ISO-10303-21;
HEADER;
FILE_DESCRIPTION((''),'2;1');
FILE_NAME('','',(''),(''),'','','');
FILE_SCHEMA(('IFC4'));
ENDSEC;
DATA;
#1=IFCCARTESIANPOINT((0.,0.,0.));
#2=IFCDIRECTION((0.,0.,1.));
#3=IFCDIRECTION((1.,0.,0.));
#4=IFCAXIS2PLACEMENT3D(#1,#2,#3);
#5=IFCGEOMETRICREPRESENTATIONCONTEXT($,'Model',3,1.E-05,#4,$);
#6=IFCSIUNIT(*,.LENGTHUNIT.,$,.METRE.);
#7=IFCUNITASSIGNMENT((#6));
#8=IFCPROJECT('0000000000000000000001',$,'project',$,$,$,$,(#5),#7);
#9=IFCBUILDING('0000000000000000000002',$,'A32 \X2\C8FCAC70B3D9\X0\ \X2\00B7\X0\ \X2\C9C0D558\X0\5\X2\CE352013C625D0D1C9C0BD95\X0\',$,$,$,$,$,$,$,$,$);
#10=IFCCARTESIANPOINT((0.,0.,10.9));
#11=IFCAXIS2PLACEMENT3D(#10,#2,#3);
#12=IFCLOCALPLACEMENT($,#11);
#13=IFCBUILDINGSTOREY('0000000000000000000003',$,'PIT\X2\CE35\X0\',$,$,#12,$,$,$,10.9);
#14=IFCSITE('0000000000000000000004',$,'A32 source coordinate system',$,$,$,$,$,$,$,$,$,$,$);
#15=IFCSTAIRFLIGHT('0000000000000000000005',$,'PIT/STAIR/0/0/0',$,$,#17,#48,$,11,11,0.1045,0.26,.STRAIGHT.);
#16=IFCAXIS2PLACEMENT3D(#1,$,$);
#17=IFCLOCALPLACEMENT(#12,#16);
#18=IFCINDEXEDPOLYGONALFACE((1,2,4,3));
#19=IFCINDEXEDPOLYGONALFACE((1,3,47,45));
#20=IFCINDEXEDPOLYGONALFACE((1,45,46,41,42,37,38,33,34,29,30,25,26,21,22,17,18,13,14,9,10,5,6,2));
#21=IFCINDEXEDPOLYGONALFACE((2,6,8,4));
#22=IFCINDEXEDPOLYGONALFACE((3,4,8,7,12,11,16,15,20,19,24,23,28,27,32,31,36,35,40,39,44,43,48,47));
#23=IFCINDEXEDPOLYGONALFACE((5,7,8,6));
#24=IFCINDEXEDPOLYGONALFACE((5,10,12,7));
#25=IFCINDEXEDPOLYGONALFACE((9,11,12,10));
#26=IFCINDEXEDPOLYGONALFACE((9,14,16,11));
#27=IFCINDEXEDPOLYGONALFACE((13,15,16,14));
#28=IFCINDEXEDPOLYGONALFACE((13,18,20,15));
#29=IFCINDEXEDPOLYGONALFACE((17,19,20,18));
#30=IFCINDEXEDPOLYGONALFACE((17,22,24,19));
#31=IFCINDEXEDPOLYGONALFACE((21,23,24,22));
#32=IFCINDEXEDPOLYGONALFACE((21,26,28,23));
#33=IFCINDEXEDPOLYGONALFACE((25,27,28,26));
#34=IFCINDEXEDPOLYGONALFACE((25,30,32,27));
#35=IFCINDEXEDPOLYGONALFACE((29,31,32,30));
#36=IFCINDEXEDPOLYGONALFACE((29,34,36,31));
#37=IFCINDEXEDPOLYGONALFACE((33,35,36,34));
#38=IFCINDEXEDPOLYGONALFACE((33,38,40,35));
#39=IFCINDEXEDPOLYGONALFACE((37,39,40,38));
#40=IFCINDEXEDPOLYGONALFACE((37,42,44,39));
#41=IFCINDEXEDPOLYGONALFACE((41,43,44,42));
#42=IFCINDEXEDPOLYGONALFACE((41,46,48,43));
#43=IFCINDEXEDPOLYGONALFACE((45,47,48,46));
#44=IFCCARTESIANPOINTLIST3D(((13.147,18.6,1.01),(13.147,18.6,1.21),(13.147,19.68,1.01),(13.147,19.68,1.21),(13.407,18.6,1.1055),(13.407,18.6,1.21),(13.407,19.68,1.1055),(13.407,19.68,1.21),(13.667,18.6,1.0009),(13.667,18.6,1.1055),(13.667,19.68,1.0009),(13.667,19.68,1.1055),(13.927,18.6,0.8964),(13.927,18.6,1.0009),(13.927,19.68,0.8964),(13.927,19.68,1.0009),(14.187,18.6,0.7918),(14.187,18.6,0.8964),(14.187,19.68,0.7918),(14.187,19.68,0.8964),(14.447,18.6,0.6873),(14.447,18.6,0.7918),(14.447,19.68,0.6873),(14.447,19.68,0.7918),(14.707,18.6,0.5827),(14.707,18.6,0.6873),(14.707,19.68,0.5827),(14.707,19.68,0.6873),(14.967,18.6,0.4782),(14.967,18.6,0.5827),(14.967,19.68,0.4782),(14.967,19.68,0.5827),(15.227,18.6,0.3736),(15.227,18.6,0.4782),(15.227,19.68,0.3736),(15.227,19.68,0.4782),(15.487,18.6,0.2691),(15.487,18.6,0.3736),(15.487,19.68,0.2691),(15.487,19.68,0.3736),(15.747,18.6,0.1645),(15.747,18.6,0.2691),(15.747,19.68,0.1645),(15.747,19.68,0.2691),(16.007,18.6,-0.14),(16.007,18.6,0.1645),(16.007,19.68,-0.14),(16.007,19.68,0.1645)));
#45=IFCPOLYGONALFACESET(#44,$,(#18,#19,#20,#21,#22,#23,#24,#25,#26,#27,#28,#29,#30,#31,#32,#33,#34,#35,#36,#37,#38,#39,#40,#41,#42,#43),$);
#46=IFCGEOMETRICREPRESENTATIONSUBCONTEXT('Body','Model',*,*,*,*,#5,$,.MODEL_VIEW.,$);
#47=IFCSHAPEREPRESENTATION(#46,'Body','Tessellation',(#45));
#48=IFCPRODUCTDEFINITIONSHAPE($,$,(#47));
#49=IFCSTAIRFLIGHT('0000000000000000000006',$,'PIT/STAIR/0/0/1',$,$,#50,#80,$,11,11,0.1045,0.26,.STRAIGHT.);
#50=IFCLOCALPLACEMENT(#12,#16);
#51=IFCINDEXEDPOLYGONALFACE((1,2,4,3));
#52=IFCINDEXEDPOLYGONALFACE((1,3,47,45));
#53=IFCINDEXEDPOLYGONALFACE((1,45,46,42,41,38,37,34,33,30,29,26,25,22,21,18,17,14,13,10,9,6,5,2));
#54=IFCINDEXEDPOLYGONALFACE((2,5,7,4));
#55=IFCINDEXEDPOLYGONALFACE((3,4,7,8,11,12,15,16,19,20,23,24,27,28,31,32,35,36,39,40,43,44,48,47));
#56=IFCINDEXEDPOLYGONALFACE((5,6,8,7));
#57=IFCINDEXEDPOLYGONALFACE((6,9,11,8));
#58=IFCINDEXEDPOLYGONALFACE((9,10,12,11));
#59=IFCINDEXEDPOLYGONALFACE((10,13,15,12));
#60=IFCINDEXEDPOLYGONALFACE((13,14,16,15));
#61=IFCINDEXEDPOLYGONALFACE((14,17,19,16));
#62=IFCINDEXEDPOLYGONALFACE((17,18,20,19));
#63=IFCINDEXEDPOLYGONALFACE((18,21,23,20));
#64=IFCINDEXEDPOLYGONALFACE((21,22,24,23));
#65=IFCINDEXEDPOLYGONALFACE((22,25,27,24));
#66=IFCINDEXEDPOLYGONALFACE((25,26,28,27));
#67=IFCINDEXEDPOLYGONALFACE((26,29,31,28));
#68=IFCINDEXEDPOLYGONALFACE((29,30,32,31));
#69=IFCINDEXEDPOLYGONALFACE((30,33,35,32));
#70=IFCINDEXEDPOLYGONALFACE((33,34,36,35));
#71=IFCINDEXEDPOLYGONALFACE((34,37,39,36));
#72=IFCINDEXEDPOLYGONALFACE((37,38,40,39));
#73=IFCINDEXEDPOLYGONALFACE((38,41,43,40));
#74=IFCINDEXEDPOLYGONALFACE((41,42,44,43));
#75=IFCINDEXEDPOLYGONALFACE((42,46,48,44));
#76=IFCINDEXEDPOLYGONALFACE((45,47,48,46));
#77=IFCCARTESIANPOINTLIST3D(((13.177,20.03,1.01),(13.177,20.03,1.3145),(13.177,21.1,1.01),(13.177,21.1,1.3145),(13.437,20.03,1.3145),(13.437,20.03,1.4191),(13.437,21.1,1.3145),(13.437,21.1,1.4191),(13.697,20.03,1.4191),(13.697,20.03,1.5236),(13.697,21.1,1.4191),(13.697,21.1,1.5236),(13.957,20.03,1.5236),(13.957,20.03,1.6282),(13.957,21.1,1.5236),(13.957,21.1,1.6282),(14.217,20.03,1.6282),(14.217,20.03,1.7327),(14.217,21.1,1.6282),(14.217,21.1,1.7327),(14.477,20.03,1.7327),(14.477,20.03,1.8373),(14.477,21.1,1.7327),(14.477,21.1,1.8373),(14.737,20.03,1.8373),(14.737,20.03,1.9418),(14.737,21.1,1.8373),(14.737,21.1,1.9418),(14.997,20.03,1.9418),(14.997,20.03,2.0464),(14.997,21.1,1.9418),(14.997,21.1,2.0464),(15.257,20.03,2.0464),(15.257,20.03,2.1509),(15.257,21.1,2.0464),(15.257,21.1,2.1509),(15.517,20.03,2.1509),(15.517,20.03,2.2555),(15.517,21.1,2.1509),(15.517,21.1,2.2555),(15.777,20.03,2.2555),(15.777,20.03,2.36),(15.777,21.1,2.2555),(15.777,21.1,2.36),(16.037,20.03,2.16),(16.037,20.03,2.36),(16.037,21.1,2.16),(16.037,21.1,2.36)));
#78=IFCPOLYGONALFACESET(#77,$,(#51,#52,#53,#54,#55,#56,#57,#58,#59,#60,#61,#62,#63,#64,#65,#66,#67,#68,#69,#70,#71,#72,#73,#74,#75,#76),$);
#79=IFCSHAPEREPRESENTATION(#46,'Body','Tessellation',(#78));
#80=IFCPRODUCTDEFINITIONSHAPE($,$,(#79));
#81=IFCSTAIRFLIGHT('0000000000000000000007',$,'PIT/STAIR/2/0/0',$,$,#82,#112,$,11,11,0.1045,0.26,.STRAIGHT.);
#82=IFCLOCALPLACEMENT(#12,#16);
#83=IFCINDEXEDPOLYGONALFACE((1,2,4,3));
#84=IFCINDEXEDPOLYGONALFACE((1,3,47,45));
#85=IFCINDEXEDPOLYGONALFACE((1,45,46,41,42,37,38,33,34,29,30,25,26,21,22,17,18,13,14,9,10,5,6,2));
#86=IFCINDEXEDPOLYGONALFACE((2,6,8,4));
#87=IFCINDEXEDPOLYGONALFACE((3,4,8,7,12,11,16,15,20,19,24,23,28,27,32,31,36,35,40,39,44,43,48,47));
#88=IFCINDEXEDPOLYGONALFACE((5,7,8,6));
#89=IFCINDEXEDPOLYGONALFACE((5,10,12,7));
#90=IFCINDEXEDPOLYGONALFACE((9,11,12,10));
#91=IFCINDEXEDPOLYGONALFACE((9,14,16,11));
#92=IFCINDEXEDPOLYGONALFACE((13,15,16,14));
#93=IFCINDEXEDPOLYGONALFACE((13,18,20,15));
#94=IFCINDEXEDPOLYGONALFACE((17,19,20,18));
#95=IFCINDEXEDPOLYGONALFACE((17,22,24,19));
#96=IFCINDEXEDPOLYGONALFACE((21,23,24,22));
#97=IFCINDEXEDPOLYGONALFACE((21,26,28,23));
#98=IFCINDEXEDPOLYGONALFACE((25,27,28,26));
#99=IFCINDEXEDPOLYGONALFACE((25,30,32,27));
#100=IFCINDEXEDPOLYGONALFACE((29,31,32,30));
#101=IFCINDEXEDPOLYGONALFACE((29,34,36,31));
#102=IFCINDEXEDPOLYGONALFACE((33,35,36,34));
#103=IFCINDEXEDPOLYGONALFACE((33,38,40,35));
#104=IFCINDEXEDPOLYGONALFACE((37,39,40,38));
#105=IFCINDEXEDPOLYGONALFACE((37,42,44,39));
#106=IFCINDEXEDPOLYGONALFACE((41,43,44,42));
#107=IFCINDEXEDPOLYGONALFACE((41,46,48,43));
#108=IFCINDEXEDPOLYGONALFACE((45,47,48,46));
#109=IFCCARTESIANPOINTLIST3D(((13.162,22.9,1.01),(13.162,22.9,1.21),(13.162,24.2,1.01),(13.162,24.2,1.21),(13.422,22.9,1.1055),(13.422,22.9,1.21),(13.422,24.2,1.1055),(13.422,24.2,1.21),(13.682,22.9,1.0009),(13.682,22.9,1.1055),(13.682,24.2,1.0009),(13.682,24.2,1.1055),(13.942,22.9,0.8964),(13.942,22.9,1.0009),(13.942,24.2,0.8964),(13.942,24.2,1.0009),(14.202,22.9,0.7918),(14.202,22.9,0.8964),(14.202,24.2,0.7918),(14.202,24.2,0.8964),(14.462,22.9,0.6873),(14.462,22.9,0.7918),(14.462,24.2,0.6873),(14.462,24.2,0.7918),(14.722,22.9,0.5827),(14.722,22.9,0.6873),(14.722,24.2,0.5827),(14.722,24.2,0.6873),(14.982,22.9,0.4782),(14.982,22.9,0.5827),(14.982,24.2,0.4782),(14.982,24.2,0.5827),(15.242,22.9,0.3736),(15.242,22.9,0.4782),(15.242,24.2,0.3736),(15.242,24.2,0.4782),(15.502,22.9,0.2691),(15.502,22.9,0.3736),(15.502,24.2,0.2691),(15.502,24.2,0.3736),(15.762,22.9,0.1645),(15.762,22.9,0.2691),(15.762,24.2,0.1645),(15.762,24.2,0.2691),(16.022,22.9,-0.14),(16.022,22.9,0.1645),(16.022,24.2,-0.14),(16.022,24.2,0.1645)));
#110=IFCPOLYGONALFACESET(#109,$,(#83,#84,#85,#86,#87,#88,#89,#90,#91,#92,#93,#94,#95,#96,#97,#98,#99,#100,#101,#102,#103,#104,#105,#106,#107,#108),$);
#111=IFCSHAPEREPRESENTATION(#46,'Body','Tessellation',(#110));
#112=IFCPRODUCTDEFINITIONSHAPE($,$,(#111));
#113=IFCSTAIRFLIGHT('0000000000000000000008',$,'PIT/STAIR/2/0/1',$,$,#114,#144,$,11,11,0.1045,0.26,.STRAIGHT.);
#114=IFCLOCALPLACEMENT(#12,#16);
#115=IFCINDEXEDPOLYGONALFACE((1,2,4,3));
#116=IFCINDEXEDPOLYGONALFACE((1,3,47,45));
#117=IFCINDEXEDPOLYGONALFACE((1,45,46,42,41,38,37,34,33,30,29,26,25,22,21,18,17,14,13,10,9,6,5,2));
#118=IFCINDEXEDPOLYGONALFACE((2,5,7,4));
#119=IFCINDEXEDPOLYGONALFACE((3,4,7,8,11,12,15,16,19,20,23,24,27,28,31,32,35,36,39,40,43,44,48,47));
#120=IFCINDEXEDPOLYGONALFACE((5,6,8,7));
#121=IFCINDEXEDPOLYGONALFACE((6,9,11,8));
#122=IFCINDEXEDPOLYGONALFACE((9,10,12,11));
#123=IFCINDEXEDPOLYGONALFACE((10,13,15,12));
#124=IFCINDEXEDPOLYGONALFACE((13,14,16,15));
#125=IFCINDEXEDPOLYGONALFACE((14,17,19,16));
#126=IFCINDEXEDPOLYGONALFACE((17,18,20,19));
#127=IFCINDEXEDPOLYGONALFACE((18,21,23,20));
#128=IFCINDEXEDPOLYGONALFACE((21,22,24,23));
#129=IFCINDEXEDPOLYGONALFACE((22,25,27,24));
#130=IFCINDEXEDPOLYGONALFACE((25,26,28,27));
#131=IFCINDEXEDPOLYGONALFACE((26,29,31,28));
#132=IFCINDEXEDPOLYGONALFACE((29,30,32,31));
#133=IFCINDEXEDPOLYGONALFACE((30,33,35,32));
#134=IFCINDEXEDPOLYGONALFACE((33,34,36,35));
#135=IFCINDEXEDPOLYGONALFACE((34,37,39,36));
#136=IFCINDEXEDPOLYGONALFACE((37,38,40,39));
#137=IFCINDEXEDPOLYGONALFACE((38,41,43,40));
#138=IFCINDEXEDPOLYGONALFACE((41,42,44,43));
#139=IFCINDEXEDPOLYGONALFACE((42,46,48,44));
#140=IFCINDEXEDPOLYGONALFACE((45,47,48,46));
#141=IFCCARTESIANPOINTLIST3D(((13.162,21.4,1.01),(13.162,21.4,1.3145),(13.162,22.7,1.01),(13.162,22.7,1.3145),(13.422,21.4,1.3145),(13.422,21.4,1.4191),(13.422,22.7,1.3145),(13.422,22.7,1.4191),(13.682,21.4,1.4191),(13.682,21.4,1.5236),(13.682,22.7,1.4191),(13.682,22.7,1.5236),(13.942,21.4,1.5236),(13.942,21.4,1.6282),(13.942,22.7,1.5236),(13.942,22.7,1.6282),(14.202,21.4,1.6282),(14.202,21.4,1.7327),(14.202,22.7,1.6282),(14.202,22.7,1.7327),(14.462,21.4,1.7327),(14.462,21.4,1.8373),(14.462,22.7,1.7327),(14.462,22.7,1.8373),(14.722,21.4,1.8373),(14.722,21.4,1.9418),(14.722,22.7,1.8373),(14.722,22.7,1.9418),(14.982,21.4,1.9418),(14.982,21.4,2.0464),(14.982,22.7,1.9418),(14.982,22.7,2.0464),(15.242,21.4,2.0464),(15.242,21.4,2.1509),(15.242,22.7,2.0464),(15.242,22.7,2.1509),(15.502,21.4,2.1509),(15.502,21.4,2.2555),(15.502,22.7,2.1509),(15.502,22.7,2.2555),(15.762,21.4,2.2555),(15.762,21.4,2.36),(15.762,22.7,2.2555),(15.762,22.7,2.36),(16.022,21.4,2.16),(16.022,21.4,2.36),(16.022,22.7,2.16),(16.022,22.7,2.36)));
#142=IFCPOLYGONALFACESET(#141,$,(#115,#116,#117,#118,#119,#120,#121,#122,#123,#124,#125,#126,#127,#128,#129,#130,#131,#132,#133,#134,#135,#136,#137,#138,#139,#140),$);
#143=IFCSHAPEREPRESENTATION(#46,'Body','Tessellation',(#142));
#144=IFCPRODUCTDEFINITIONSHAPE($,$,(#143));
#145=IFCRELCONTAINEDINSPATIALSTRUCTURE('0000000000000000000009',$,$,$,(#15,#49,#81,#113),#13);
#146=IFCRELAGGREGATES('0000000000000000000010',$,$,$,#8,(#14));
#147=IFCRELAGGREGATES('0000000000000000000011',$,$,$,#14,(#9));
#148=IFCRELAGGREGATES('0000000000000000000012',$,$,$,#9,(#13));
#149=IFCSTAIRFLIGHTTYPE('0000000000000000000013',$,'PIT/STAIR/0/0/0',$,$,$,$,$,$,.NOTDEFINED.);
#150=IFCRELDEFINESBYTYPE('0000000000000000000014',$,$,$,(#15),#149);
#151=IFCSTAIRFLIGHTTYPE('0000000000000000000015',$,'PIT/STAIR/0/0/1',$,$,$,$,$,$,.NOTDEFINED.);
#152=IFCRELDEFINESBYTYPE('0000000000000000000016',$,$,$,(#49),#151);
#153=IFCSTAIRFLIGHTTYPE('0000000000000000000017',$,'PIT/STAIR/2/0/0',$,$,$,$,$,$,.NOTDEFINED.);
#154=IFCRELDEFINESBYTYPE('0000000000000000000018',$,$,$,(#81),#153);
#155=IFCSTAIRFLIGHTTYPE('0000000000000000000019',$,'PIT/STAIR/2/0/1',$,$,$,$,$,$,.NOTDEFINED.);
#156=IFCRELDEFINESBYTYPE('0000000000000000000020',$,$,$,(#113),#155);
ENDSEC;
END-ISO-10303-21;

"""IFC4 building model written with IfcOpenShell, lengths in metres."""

from ifc_helpers import new_model, si_unit, frame, origin, origin_with_axes, place, context, subcontext, project, spatial, polyline, outline, extrude, source, transform, mapped, type_object, type_shapes, element, save


model = new_model("IFC4")

# Units and contexts
model_context = context("Model", 3, precision=1e-05, world=origin_with_axes())
body_context = subcontext(model_context, "Body", "Model", "MODEL_VIEW")
ifc_project = project(units=[si_unit("LENGTHUNIT", "METRE")], contexts=[model_context])

# Site, building, storey
site = spatial("IfcSite", under=ifc_project, Name="A32 source coordinate system")
building = spatial("IfcBuilding", under=site, Name="A32 주거동 · 지하5층–옥탑지붕")
storey_placement = place(None, frame((0.0, 0.0, 10.9), z_axis=(0.0, 0.0, 1.0), x_axis=(1.0, 0.0, 0.0)))
storey = spatial("IfcBuildingStorey", under=building, at=storey_placement, Name="PIT층", Elevation=10.9)

# Stair flights
stair_flight_type_1 = type_object("IfcStairFlightType", Name="PIT/STAIR/0/0/0", PredefinedType="NOTDEFINED")
shared_shape_1 = source(origin(), body_context, "Body", "SweptSolid", [
    extrude(outline(polyline([(0.0, -0.14), (2.86, 1.01), (2.86, 1.21), (2.6, 1.21), (2.6, 1.1055), (2.34, 1.1055), (2.34, 1.0009), (2.08, 1.0009), (2.08, 0.8964), (1.82, 0.8964), (1.82, 0.7918), (1.56, 0.7918), (1.56, 0.6873), (1.3, 0.6873), (1.3, 0.5827), (1.04, 0.5827), (1.04, 0.4782), (0.78, 0.4782), (0.78, 0.3736), (0.52, 0.3736), (0.52, 0.2691), (0.26, 0.2691), (0.26, 0.1645), (0.0, 0.1645), (0.0, -0.14)])), frame((16.007, 18.6, 0.0), z_axis=(0.0, 1.0, 0.0), x_axis=(-1.0, 0.0, 0.0)), (0.0, 0.0, 1.0), 1.08),
])
type_shapes(stair_flight_type_1, [shared_shape_1])
stair_flight_1_placement = place(storey_placement, origin_with_axes())
element("IfcStairFlight", 1, at=stair_flight_1_placement, inside=storey, type_object=stair_flight_type_1, Name="PIT/STAIR/0/0/0", NumberOfRisers=11, NumberOfTreads=11, PredefinedType="STRAIGHT", RiserHeight=0.1045, TreadLength=0.26, context=body_context, shape_type="MappedRepresentation", body=[
    mapped(shared_shape_1, transform((0.0, 0.0, 0.0), scale=1.0)),
])
stair_flight_type_2 = type_object("IfcStairFlightType", Name="PIT/STAIR/0/0/1", PredefinedType="NOTDEFINED")
shared_shape_2 = source(origin(), body_context, "Body", "SweptSolid", [
    extrude(outline(polyline([(0.0, 1.01), (2.86, 2.16), (2.86, 2.36), (2.6, 2.36), (2.6, 2.2555), (2.34, 2.2555), (2.34, 2.1509), (2.08, 2.1509), (2.08, 2.0464), (1.82, 2.0464), (1.82, 1.9418), (1.56, 1.9418), (1.56, 1.8373), (1.3, 1.8373), (1.3, 1.7327), (1.04, 1.7327), (1.04, 1.6282), (0.78, 1.6282), (0.78, 1.5236), (0.52, 1.5236), (0.52, 1.4191), (0.26, 1.4191), (0.26, 1.3145), (0.0, 1.3145), (0.0, 1.01)])), frame((13.177, 21.1, 0.0), z_axis=(0.0, -1.0, 0.0), x_axis=(1.0, 0.0, 0.0)), (0.0, 0.0, 1.0), 1.07),
])
type_shapes(stair_flight_type_2, [shared_shape_2])
stair_flight_2_placement = place(storey_placement, origin_with_axes())
element("IfcStairFlight", 2, at=stair_flight_2_placement, inside=storey, type_object=stair_flight_type_2, Name="PIT/STAIR/0/0/1", NumberOfRisers=11, NumberOfTreads=11, PredefinedType="STRAIGHT", RiserHeight=0.1045, TreadLength=0.26, context=body_context, shape_type="MappedRepresentation", body=[
    mapped(shared_shape_2, transform((0.0, 0.0, 0.0), scale=1.0)),
])
stair_flight_type_3 = type_object("IfcStairFlightType", Name="PIT/STAIR/2/0/0", PredefinedType="NOTDEFINED")
shared_shape_3 = source(origin(), body_context, "Body", "SweptSolid", [
    extrude(outline(polyline([(0.0, -0.14), (2.86, 1.01), (2.86, 1.21), (2.6, 1.21), (2.6, 1.1055), (2.34, 1.1055), (2.34, 1.0009), (2.08, 1.0009), (2.08, 0.8964), (1.82, 0.8964), (1.82, 0.7918), (1.56, 0.7918), (1.56, 0.6873), (1.3, 0.6873), (1.3, 0.5827), (1.04, 0.5827), (1.04, 0.4782), (0.78, 0.4782), (0.78, 0.3736), (0.52, 0.3736), (0.52, 0.2691), (0.26, 0.2691), (0.26, 0.1645), (0.0, 0.1645), (0.0, -0.14)])), frame((16.022, 22.9, 0.0), z_axis=(0.0, 1.0, 0.0), x_axis=(-1.0, 0.0, 0.0)), (0.0, 0.0, 1.0), 1.3),
])
type_shapes(stair_flight_type_3, [shared_shape_3])
stair_flight_3_placement = place(storey_placement, origin_with_axes())
element("IfcStairFlight", 3, at=stair_flight_3_placement, inside=storey, type_object=stair_flight_type_3, Name="PIT/STAIR/2/0/0", NumberOfRisers=11, NumberOfTreads=11, PredefinedType="STRAIGHT", RiserHeight=0.1045, TreadLength=0.26, context=body_context, shape_type="MappedRepresentation", body=[
    mapped(shared_shape_3, transform((0.0, 0.0, 0.0), scale=1.0)),
])
stair_flight_type_4 = type_object("IfcStairFlightType", Name="PIT/STAIR/2/0/1", PredefinedType="NOTDEFINED")
shared_shape_4 = source(origin(), body_context, "Body", "SweptSolid", [
    extrude(outline(polyline([(0.0, 1.01), (2.86, 2.16), (2.86, 2.36), (2.6, 2.36), (2.6, 2.2555), (2.34, 2.2555), (2.34, 2.1509), (2.08, 2.1509), (2.08, 2.0464), (1.82, 2.0464), (1.82, 1.9418), (1.56, 1.9418), (1.56, 1.8373), (1.3, 1.8373), (1.3, 1.7327), (1.04, 1.7327), (1.04, 1.6282), (0.78, 1.6282), (0.78, 1.5236), (0.52, 1.5236), (0.52, 1.4191), (0.26, 1.4191), (0.26, 1.3145), (0.0, 1.3145), (0.0, 1.01)])), frame((13.162, 22.7, 0.0), z_axis=(0.0, -1.0, 0.0), x_axis=(1.0, 0.0, 0.0)), (0.0, 0.0, 1.0), 1.3),
])
type_shapes(stair_flight_type_4, [shared_shape_4])
stair_flight_4_placement = place(storey_placement, origin_with_axes())
element("IfcStairFlight", 4, at=stair_flight_4_placement, inside=storey, type_object=stair_flight_type_4, Name="PIT/STAIR/2/0/1", NumberOfRisers=11, NumberOfTreads=11, PredefinedType="STRAIGHT", RiserHeight=0.1045, TreadLength=0.26, context=body_context, shape_type="MappedRepresentation", body=[
    mapped(shared_shape_4, transform((0.0, 0.0, 0.0), scale=1.0)),
])

save(model, "model.ifc")
